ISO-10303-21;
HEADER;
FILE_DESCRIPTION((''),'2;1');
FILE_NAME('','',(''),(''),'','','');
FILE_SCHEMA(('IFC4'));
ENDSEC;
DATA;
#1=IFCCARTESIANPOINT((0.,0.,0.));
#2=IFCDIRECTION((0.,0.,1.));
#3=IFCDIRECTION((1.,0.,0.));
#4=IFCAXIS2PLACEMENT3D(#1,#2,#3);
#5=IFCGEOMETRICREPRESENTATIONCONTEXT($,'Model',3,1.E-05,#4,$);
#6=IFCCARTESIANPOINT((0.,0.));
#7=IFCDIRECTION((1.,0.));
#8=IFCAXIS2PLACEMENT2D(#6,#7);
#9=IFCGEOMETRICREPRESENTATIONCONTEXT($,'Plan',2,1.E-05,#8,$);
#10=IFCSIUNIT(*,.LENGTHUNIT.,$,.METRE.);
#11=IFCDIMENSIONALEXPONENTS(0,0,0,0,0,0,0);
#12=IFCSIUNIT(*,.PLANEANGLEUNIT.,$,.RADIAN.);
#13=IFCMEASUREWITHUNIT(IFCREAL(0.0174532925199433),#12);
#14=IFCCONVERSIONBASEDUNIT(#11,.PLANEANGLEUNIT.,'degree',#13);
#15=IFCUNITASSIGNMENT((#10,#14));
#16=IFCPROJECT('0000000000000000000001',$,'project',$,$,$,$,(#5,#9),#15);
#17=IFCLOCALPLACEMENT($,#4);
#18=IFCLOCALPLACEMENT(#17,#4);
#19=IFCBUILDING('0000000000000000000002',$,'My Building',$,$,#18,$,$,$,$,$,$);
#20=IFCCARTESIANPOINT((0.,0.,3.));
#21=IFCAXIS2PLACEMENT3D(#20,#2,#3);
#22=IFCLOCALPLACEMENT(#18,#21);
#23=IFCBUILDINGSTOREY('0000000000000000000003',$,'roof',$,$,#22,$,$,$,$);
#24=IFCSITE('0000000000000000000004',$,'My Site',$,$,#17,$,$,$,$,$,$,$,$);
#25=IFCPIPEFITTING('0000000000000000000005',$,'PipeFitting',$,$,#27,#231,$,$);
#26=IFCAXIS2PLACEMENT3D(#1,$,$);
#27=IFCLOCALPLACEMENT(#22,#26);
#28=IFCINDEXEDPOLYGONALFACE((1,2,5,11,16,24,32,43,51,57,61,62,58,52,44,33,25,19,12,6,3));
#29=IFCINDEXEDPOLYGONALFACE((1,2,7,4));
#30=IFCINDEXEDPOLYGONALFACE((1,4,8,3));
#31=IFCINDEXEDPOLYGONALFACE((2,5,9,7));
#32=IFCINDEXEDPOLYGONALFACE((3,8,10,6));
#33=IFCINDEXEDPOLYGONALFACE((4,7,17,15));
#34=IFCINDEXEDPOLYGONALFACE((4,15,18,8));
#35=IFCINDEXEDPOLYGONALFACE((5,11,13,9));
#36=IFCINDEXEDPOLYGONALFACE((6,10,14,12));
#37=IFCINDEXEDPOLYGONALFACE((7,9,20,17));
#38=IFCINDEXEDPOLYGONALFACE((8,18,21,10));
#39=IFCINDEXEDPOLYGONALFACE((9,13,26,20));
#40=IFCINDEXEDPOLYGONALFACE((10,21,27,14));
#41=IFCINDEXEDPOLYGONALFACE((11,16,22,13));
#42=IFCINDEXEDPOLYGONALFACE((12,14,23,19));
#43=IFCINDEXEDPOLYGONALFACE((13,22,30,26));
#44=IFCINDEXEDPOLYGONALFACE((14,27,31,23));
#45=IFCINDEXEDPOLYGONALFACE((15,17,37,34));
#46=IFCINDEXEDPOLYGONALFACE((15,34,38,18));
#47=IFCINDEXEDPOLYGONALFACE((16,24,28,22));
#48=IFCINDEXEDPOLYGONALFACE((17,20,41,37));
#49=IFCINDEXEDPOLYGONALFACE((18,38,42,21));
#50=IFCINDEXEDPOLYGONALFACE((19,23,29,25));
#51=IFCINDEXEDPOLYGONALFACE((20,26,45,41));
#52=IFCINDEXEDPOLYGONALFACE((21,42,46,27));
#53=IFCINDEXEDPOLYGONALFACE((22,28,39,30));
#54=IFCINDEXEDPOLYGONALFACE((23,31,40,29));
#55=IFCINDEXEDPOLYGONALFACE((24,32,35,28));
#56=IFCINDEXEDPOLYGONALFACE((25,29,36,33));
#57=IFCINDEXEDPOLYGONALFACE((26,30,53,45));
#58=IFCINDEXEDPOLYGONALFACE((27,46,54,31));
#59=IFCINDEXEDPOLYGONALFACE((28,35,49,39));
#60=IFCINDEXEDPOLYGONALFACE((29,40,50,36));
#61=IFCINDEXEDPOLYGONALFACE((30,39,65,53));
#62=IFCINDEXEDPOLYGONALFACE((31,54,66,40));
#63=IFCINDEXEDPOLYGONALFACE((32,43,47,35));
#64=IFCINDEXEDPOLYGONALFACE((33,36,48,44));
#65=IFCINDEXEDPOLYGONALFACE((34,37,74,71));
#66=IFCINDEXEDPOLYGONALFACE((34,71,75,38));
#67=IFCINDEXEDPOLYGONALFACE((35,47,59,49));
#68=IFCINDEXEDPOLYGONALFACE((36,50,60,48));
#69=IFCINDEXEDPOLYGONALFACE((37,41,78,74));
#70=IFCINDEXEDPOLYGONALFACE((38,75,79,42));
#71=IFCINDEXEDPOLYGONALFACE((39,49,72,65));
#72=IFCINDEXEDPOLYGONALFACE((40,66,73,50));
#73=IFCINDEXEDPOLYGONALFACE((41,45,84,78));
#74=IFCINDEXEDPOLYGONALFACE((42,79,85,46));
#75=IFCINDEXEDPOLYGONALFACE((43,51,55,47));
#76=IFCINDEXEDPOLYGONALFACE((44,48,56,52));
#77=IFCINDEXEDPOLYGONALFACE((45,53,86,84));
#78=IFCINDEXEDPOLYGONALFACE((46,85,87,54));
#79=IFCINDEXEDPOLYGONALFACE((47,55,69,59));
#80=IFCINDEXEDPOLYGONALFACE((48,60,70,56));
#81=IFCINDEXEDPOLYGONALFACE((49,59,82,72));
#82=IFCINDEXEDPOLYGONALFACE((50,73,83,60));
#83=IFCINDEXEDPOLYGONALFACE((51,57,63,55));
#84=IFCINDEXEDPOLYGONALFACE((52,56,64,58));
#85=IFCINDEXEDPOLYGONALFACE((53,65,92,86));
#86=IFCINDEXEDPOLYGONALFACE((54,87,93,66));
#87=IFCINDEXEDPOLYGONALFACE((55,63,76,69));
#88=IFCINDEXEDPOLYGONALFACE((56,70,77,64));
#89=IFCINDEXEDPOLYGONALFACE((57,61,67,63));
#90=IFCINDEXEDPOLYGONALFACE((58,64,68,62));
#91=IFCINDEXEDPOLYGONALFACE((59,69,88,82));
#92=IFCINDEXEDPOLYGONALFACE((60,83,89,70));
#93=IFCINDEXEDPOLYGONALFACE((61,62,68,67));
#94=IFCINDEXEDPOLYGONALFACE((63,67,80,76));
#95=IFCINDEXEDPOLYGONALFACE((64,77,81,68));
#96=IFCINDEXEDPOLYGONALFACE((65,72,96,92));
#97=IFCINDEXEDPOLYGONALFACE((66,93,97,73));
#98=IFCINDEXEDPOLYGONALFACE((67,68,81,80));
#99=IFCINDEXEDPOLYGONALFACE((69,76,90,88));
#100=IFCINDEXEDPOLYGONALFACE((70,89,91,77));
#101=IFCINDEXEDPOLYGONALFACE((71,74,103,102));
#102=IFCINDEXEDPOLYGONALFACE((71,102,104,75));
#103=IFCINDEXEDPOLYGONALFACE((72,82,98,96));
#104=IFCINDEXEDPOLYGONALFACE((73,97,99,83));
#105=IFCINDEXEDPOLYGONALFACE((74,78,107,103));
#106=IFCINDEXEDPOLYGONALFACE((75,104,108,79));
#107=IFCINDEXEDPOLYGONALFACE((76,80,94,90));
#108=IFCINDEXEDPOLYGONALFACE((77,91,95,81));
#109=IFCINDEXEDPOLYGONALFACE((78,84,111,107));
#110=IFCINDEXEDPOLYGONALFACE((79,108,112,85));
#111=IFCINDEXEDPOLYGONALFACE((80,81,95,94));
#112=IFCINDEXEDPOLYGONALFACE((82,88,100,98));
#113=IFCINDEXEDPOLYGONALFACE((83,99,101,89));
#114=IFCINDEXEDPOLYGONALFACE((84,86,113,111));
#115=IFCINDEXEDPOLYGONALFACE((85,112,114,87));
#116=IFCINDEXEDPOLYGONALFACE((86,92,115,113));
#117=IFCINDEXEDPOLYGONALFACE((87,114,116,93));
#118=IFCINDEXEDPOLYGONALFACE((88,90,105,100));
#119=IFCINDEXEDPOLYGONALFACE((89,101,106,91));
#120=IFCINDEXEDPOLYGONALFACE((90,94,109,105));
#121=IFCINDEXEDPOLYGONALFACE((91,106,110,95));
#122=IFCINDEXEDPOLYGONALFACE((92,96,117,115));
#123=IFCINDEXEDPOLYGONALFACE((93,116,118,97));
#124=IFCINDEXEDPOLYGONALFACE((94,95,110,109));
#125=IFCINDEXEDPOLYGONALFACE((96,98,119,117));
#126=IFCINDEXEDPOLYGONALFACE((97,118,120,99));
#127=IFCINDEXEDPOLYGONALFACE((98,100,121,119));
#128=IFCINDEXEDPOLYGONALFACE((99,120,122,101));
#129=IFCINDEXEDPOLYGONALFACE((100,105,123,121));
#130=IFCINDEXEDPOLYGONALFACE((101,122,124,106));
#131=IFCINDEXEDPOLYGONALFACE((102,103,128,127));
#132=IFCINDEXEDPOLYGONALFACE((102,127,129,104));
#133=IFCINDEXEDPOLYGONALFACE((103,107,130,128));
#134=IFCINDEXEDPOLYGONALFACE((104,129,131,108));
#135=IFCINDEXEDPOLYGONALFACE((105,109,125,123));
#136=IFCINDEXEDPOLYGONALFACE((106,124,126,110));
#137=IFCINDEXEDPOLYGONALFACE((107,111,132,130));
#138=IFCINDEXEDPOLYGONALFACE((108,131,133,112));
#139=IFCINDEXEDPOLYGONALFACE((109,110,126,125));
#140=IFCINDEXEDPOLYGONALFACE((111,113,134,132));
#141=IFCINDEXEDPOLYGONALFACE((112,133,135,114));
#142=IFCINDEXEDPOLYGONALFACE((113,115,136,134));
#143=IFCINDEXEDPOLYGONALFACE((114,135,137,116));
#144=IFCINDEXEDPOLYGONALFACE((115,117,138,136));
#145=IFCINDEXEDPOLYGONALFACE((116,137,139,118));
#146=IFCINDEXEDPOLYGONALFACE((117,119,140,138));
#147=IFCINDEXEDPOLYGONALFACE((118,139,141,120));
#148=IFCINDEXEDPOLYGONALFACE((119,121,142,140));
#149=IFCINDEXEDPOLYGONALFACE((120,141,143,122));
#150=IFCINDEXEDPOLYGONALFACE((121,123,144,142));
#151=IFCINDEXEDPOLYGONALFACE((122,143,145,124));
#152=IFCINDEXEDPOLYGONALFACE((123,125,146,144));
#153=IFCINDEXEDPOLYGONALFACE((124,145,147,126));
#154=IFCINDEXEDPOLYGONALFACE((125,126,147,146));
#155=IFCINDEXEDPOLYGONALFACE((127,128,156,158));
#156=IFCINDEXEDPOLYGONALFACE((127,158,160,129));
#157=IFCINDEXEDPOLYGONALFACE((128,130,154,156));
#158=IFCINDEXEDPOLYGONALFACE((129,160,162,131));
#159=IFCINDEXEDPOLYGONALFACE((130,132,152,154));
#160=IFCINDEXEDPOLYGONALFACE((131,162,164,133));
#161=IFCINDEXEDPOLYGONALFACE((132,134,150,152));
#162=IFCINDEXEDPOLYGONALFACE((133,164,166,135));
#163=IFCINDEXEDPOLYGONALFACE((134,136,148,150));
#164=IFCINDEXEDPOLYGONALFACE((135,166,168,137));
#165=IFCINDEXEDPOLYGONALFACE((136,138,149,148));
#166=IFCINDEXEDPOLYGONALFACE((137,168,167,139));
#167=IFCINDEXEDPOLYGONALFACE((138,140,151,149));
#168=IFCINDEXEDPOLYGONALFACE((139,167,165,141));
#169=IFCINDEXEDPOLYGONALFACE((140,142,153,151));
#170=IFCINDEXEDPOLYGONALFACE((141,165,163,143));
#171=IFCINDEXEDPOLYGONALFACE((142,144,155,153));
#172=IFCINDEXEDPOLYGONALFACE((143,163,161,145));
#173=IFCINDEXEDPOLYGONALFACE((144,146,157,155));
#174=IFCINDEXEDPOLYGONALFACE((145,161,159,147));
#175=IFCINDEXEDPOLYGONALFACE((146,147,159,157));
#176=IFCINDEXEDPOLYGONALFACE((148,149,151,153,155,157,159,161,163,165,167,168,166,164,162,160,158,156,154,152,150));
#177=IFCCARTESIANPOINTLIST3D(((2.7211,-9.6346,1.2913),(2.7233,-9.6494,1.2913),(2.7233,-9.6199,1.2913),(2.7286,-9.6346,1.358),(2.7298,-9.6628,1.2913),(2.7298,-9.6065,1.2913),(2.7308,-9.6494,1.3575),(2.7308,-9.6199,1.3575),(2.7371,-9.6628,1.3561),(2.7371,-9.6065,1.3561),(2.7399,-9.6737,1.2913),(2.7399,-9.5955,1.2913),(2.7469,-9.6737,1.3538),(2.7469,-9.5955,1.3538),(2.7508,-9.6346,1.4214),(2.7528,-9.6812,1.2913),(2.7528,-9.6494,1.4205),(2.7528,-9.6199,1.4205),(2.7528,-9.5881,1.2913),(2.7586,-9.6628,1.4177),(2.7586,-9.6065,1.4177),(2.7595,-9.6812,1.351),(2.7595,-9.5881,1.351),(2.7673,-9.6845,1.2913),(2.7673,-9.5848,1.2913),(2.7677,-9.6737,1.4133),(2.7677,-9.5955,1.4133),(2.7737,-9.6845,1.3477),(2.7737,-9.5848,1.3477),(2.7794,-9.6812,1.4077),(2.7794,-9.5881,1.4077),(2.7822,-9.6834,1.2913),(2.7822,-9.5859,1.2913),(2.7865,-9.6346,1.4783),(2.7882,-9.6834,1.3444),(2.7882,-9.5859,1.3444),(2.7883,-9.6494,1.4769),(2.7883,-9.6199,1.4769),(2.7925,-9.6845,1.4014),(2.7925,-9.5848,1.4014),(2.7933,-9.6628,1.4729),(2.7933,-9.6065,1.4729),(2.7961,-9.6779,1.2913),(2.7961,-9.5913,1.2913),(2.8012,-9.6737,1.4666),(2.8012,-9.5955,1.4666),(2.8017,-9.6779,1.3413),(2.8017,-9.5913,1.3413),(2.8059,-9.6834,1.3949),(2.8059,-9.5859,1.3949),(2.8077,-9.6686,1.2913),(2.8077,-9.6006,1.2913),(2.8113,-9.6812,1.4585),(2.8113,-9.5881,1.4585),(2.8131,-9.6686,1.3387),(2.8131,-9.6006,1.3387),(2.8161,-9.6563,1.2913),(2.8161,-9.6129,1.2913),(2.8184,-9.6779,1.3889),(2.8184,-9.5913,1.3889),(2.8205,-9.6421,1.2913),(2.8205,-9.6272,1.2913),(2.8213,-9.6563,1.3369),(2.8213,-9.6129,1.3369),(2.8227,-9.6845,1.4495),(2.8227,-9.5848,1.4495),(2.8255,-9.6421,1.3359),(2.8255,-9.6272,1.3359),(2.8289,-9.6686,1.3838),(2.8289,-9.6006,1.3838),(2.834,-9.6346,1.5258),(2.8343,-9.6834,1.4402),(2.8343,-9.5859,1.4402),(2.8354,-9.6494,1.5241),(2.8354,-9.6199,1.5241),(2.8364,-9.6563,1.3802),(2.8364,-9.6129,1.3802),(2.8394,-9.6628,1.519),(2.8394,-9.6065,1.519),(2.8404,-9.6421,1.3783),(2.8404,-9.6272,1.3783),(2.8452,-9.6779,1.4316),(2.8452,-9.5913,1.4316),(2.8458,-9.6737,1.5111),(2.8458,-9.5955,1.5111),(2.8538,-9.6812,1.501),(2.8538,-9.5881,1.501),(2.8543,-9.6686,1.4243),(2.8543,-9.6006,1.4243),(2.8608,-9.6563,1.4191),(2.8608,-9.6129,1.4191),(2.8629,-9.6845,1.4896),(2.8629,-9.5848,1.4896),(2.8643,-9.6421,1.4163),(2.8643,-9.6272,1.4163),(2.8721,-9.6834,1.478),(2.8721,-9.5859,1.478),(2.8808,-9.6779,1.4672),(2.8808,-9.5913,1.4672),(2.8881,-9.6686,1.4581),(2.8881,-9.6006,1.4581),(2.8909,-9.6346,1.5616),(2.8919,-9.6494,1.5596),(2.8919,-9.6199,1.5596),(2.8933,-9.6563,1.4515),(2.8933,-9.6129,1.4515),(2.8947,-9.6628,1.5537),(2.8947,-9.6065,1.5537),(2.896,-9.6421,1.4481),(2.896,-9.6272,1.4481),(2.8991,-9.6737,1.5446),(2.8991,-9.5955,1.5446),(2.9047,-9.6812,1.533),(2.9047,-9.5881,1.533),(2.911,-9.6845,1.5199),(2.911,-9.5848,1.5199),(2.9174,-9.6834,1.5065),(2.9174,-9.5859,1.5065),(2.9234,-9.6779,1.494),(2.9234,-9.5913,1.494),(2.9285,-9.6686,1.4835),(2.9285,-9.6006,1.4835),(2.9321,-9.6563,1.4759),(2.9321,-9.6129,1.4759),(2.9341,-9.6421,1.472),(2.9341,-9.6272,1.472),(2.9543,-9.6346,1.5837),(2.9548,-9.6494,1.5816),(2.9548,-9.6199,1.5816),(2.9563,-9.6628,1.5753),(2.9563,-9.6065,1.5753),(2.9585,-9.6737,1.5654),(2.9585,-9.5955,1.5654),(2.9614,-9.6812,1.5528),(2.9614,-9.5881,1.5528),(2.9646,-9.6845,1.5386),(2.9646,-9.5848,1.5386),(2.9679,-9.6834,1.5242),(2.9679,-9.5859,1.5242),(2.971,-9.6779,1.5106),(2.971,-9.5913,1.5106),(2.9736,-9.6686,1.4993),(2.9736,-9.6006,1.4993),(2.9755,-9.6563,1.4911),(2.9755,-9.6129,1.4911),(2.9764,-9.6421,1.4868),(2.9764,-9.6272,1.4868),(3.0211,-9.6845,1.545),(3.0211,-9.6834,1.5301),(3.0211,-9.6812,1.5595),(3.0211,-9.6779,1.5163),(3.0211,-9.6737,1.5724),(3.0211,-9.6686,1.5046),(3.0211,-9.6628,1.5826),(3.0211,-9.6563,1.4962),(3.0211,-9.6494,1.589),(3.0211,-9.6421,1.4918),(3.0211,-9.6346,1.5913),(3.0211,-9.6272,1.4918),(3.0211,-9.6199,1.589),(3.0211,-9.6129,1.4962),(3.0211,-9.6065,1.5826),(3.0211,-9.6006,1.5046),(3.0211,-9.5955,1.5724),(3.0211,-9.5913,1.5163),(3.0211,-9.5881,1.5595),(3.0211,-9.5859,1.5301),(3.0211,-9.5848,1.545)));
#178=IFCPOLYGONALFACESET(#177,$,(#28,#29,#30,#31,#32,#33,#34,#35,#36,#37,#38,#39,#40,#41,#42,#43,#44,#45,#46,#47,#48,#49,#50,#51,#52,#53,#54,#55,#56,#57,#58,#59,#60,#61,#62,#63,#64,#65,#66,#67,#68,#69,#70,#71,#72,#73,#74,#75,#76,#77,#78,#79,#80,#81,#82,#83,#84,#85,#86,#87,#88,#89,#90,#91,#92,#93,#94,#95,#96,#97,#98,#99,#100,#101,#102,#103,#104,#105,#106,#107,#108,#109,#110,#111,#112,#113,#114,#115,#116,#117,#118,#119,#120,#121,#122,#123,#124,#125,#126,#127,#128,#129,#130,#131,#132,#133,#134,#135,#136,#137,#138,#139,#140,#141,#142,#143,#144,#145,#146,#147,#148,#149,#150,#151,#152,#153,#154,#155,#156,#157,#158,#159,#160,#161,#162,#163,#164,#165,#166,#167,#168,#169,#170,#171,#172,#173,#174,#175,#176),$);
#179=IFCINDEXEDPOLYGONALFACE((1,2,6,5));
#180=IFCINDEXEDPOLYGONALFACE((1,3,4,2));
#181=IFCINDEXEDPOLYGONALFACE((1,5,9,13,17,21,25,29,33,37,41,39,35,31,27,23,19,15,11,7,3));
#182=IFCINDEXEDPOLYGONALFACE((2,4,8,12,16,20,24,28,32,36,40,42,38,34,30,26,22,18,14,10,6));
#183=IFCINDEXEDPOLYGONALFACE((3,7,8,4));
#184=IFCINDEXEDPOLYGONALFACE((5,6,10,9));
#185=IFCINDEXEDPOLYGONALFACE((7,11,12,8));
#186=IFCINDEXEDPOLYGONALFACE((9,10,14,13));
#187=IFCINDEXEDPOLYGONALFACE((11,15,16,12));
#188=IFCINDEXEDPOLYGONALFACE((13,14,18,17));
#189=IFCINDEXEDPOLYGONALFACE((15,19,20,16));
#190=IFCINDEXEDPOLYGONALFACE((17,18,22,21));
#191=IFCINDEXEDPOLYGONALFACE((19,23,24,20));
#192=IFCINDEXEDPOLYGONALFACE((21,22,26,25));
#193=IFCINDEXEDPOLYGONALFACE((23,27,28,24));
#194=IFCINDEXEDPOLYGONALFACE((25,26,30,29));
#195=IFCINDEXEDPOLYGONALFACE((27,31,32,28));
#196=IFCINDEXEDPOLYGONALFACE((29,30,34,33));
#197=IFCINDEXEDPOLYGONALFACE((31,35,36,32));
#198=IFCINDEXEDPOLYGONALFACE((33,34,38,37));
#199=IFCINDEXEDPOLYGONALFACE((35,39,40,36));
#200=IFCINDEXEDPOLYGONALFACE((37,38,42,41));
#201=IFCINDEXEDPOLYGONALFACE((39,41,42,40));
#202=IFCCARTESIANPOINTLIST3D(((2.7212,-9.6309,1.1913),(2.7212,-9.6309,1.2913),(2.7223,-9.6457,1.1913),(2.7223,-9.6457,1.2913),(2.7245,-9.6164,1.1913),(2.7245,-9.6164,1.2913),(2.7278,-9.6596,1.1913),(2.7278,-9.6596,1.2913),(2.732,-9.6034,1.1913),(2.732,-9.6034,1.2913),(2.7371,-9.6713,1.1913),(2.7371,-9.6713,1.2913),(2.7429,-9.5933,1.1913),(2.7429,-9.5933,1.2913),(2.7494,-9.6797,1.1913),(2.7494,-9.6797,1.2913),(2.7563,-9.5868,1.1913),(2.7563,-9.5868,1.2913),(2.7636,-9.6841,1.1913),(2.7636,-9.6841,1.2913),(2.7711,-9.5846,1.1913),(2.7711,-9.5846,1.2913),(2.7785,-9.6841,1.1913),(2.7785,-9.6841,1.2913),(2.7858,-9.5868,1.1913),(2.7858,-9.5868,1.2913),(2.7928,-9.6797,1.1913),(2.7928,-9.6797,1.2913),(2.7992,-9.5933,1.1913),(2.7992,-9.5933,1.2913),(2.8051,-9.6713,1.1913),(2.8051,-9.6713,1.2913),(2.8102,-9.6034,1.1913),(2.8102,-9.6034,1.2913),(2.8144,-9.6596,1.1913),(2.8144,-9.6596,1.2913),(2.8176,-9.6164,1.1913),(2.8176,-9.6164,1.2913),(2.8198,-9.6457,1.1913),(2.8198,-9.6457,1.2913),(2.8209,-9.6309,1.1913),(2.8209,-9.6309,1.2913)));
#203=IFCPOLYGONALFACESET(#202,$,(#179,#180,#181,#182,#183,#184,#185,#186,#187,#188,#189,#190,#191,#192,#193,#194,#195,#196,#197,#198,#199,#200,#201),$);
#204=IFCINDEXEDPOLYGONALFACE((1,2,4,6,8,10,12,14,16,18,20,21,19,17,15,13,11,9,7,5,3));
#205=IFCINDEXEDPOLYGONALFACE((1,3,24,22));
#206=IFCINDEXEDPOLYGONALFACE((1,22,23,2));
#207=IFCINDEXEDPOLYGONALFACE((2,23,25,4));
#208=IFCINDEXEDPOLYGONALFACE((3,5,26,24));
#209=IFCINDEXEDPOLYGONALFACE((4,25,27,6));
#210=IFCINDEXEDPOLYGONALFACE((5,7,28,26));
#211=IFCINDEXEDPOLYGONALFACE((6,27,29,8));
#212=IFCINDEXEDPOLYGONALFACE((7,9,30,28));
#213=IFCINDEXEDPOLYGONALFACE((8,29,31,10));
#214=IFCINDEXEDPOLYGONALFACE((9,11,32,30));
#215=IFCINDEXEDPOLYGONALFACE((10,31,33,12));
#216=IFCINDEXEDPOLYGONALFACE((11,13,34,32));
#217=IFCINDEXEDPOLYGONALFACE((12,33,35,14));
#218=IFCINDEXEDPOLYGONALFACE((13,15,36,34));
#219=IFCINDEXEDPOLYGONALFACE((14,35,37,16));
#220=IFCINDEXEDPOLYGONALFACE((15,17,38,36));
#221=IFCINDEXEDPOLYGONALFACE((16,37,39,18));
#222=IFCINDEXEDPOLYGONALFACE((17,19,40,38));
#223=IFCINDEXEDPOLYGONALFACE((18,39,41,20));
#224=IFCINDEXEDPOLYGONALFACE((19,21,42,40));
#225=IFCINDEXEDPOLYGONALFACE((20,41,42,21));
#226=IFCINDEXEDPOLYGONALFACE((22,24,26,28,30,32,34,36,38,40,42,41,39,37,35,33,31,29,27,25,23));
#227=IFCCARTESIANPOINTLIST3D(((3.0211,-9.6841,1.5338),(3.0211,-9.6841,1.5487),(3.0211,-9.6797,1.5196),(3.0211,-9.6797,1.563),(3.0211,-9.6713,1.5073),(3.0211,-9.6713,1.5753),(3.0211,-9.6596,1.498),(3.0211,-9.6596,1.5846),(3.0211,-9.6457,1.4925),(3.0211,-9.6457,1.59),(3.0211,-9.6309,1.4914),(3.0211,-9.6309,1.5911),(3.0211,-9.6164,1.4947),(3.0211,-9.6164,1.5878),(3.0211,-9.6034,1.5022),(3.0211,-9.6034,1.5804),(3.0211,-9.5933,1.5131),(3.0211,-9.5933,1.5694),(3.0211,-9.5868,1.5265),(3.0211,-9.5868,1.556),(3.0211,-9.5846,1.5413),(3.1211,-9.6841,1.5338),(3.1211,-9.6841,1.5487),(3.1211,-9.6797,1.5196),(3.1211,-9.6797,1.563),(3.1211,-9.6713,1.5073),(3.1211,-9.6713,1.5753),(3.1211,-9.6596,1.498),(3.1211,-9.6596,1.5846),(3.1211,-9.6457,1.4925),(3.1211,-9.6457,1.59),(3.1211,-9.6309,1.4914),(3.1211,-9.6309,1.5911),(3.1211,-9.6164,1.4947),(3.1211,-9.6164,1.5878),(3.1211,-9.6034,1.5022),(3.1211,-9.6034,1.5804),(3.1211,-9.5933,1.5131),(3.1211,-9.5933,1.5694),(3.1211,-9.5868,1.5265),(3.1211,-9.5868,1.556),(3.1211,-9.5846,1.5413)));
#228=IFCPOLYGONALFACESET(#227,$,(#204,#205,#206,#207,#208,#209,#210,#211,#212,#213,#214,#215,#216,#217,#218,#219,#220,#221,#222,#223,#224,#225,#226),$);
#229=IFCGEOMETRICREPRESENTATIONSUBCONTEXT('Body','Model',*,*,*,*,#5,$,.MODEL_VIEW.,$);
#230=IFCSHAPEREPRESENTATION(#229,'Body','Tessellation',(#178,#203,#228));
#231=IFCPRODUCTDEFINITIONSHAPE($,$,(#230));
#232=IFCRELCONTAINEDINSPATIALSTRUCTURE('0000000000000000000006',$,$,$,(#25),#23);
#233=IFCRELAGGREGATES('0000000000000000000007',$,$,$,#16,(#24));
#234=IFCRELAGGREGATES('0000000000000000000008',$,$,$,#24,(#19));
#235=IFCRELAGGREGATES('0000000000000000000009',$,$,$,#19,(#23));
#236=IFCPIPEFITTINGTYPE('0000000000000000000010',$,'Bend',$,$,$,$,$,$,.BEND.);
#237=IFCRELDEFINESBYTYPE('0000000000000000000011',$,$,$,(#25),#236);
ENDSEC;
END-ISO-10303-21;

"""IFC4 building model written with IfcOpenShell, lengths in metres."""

from ifc_helpers import new_model, entity, si_unit, converted_unit, frame, origin_with_axes, origin_2d_with_axis, place, context, subcontext, project, spatial, circle, extrude, source, transform, mapped, type_object, type_shapes, element, save


model = new_model("IFC4")

# Units and contexts
model_context = context("Model", 3, precision=1e-05, world=origin_with_axes())
plan_context = context("Plan", 2, precision=1e-05, world=origin_2d_with_axis())
body_context_1 = subcontext(model_context, "Body", "Model", "MODEL_VIEW")
ifc_project = project(units=[si_unit("LENGTHUNIT", "METRE"), converted_unit("PLANEANGLEUNIT", "degree", entity("IfcReal", 0.0174532925199433), si_unit("PLANEANGLEUNIT", "RADIAN"), dimensions=[0, 0, 0, 0, 0, 0, 0])], contexts=[model_context, plan_context])

# Site, building, storey
site_placement = place(None, origin_with_axes())
site = spatial("IfcSite", under=ifc_project, at=site_placement, Name="My Site")
building_placement = place(site_placement, origin_with_axes())
building = spatial("IfcBuilding", under=site, at=building_placement, Name="My Building")
storey_placement = place(building_placement, frame((0.0, 0.0, 3.0), z_axis=(0.0, 0.0, 1.0), x_axis=(1.0, 0.0, 0.0)))
storey = spatial("IfcBuildingStorey", under=building, at=storey_placement, Name="roof")

# Pipe fitting
pipe_fitting_type_1 = type_object("IfcPipeFittingType", Name="Bend", PredefinedType="BEND")
shared_shape_1 = source(origin_with_axes(), body_context_1, "Body", "SolidModel", [
    entity("IfcSweptDiskSolid", entity("IfcIndexedPolyCurve", entity("IfcCartesianPointList3D", [[0.0, 0.0, 0.1], [0.0, -0.0732, 0.2768], [0.0, -0.25, 0.35]]), [entity("IfcArcIndex", [1, 2, 3])]), 0.05),
    extrude(circle(Radius=0.05), origin_with_axes(), (0.0, 0.0, 1.0), 0.1),
    extrude(circle(Radius=0.05), frame((0.0, -0.25, 0.35), z_axis=(0.0, -1.0, 0.0), x_axis=(1.0, 0.0, 0.0)), (0.0, 0.0, 1.0), 0.1),
])
type_shapes(pipe_fitting_type_1, [shared_shape_1])
for number, where, z_axis, x_axis, name in (
    (1, (2.7711, -9.6346, 1.1913), (-0.000001, 0.000001, 1.0), (0.0, 1.0, -0.000001), "PipeFitting"),
):
    element("IfcPipeFitting", number, at=place(storey_placement, frame(where, z_axis=z_axis, x_axis=x_axis)), inside=storey, type_object=pipe_fitting_type_1, Name=name, context=body_context_1, shape_type="MappedRepresentation", body=[
        mapped(shared_shape_1, transform((0.0, 0.0, 0.0), x_axis=(1.0, 0.0, 0.0), y_axis=(0.0, 1.0, 0.0), z_axis=(0.0, 0.0, 1.0), scale=1.0)),
    ])

save(model, "model.ifc")
